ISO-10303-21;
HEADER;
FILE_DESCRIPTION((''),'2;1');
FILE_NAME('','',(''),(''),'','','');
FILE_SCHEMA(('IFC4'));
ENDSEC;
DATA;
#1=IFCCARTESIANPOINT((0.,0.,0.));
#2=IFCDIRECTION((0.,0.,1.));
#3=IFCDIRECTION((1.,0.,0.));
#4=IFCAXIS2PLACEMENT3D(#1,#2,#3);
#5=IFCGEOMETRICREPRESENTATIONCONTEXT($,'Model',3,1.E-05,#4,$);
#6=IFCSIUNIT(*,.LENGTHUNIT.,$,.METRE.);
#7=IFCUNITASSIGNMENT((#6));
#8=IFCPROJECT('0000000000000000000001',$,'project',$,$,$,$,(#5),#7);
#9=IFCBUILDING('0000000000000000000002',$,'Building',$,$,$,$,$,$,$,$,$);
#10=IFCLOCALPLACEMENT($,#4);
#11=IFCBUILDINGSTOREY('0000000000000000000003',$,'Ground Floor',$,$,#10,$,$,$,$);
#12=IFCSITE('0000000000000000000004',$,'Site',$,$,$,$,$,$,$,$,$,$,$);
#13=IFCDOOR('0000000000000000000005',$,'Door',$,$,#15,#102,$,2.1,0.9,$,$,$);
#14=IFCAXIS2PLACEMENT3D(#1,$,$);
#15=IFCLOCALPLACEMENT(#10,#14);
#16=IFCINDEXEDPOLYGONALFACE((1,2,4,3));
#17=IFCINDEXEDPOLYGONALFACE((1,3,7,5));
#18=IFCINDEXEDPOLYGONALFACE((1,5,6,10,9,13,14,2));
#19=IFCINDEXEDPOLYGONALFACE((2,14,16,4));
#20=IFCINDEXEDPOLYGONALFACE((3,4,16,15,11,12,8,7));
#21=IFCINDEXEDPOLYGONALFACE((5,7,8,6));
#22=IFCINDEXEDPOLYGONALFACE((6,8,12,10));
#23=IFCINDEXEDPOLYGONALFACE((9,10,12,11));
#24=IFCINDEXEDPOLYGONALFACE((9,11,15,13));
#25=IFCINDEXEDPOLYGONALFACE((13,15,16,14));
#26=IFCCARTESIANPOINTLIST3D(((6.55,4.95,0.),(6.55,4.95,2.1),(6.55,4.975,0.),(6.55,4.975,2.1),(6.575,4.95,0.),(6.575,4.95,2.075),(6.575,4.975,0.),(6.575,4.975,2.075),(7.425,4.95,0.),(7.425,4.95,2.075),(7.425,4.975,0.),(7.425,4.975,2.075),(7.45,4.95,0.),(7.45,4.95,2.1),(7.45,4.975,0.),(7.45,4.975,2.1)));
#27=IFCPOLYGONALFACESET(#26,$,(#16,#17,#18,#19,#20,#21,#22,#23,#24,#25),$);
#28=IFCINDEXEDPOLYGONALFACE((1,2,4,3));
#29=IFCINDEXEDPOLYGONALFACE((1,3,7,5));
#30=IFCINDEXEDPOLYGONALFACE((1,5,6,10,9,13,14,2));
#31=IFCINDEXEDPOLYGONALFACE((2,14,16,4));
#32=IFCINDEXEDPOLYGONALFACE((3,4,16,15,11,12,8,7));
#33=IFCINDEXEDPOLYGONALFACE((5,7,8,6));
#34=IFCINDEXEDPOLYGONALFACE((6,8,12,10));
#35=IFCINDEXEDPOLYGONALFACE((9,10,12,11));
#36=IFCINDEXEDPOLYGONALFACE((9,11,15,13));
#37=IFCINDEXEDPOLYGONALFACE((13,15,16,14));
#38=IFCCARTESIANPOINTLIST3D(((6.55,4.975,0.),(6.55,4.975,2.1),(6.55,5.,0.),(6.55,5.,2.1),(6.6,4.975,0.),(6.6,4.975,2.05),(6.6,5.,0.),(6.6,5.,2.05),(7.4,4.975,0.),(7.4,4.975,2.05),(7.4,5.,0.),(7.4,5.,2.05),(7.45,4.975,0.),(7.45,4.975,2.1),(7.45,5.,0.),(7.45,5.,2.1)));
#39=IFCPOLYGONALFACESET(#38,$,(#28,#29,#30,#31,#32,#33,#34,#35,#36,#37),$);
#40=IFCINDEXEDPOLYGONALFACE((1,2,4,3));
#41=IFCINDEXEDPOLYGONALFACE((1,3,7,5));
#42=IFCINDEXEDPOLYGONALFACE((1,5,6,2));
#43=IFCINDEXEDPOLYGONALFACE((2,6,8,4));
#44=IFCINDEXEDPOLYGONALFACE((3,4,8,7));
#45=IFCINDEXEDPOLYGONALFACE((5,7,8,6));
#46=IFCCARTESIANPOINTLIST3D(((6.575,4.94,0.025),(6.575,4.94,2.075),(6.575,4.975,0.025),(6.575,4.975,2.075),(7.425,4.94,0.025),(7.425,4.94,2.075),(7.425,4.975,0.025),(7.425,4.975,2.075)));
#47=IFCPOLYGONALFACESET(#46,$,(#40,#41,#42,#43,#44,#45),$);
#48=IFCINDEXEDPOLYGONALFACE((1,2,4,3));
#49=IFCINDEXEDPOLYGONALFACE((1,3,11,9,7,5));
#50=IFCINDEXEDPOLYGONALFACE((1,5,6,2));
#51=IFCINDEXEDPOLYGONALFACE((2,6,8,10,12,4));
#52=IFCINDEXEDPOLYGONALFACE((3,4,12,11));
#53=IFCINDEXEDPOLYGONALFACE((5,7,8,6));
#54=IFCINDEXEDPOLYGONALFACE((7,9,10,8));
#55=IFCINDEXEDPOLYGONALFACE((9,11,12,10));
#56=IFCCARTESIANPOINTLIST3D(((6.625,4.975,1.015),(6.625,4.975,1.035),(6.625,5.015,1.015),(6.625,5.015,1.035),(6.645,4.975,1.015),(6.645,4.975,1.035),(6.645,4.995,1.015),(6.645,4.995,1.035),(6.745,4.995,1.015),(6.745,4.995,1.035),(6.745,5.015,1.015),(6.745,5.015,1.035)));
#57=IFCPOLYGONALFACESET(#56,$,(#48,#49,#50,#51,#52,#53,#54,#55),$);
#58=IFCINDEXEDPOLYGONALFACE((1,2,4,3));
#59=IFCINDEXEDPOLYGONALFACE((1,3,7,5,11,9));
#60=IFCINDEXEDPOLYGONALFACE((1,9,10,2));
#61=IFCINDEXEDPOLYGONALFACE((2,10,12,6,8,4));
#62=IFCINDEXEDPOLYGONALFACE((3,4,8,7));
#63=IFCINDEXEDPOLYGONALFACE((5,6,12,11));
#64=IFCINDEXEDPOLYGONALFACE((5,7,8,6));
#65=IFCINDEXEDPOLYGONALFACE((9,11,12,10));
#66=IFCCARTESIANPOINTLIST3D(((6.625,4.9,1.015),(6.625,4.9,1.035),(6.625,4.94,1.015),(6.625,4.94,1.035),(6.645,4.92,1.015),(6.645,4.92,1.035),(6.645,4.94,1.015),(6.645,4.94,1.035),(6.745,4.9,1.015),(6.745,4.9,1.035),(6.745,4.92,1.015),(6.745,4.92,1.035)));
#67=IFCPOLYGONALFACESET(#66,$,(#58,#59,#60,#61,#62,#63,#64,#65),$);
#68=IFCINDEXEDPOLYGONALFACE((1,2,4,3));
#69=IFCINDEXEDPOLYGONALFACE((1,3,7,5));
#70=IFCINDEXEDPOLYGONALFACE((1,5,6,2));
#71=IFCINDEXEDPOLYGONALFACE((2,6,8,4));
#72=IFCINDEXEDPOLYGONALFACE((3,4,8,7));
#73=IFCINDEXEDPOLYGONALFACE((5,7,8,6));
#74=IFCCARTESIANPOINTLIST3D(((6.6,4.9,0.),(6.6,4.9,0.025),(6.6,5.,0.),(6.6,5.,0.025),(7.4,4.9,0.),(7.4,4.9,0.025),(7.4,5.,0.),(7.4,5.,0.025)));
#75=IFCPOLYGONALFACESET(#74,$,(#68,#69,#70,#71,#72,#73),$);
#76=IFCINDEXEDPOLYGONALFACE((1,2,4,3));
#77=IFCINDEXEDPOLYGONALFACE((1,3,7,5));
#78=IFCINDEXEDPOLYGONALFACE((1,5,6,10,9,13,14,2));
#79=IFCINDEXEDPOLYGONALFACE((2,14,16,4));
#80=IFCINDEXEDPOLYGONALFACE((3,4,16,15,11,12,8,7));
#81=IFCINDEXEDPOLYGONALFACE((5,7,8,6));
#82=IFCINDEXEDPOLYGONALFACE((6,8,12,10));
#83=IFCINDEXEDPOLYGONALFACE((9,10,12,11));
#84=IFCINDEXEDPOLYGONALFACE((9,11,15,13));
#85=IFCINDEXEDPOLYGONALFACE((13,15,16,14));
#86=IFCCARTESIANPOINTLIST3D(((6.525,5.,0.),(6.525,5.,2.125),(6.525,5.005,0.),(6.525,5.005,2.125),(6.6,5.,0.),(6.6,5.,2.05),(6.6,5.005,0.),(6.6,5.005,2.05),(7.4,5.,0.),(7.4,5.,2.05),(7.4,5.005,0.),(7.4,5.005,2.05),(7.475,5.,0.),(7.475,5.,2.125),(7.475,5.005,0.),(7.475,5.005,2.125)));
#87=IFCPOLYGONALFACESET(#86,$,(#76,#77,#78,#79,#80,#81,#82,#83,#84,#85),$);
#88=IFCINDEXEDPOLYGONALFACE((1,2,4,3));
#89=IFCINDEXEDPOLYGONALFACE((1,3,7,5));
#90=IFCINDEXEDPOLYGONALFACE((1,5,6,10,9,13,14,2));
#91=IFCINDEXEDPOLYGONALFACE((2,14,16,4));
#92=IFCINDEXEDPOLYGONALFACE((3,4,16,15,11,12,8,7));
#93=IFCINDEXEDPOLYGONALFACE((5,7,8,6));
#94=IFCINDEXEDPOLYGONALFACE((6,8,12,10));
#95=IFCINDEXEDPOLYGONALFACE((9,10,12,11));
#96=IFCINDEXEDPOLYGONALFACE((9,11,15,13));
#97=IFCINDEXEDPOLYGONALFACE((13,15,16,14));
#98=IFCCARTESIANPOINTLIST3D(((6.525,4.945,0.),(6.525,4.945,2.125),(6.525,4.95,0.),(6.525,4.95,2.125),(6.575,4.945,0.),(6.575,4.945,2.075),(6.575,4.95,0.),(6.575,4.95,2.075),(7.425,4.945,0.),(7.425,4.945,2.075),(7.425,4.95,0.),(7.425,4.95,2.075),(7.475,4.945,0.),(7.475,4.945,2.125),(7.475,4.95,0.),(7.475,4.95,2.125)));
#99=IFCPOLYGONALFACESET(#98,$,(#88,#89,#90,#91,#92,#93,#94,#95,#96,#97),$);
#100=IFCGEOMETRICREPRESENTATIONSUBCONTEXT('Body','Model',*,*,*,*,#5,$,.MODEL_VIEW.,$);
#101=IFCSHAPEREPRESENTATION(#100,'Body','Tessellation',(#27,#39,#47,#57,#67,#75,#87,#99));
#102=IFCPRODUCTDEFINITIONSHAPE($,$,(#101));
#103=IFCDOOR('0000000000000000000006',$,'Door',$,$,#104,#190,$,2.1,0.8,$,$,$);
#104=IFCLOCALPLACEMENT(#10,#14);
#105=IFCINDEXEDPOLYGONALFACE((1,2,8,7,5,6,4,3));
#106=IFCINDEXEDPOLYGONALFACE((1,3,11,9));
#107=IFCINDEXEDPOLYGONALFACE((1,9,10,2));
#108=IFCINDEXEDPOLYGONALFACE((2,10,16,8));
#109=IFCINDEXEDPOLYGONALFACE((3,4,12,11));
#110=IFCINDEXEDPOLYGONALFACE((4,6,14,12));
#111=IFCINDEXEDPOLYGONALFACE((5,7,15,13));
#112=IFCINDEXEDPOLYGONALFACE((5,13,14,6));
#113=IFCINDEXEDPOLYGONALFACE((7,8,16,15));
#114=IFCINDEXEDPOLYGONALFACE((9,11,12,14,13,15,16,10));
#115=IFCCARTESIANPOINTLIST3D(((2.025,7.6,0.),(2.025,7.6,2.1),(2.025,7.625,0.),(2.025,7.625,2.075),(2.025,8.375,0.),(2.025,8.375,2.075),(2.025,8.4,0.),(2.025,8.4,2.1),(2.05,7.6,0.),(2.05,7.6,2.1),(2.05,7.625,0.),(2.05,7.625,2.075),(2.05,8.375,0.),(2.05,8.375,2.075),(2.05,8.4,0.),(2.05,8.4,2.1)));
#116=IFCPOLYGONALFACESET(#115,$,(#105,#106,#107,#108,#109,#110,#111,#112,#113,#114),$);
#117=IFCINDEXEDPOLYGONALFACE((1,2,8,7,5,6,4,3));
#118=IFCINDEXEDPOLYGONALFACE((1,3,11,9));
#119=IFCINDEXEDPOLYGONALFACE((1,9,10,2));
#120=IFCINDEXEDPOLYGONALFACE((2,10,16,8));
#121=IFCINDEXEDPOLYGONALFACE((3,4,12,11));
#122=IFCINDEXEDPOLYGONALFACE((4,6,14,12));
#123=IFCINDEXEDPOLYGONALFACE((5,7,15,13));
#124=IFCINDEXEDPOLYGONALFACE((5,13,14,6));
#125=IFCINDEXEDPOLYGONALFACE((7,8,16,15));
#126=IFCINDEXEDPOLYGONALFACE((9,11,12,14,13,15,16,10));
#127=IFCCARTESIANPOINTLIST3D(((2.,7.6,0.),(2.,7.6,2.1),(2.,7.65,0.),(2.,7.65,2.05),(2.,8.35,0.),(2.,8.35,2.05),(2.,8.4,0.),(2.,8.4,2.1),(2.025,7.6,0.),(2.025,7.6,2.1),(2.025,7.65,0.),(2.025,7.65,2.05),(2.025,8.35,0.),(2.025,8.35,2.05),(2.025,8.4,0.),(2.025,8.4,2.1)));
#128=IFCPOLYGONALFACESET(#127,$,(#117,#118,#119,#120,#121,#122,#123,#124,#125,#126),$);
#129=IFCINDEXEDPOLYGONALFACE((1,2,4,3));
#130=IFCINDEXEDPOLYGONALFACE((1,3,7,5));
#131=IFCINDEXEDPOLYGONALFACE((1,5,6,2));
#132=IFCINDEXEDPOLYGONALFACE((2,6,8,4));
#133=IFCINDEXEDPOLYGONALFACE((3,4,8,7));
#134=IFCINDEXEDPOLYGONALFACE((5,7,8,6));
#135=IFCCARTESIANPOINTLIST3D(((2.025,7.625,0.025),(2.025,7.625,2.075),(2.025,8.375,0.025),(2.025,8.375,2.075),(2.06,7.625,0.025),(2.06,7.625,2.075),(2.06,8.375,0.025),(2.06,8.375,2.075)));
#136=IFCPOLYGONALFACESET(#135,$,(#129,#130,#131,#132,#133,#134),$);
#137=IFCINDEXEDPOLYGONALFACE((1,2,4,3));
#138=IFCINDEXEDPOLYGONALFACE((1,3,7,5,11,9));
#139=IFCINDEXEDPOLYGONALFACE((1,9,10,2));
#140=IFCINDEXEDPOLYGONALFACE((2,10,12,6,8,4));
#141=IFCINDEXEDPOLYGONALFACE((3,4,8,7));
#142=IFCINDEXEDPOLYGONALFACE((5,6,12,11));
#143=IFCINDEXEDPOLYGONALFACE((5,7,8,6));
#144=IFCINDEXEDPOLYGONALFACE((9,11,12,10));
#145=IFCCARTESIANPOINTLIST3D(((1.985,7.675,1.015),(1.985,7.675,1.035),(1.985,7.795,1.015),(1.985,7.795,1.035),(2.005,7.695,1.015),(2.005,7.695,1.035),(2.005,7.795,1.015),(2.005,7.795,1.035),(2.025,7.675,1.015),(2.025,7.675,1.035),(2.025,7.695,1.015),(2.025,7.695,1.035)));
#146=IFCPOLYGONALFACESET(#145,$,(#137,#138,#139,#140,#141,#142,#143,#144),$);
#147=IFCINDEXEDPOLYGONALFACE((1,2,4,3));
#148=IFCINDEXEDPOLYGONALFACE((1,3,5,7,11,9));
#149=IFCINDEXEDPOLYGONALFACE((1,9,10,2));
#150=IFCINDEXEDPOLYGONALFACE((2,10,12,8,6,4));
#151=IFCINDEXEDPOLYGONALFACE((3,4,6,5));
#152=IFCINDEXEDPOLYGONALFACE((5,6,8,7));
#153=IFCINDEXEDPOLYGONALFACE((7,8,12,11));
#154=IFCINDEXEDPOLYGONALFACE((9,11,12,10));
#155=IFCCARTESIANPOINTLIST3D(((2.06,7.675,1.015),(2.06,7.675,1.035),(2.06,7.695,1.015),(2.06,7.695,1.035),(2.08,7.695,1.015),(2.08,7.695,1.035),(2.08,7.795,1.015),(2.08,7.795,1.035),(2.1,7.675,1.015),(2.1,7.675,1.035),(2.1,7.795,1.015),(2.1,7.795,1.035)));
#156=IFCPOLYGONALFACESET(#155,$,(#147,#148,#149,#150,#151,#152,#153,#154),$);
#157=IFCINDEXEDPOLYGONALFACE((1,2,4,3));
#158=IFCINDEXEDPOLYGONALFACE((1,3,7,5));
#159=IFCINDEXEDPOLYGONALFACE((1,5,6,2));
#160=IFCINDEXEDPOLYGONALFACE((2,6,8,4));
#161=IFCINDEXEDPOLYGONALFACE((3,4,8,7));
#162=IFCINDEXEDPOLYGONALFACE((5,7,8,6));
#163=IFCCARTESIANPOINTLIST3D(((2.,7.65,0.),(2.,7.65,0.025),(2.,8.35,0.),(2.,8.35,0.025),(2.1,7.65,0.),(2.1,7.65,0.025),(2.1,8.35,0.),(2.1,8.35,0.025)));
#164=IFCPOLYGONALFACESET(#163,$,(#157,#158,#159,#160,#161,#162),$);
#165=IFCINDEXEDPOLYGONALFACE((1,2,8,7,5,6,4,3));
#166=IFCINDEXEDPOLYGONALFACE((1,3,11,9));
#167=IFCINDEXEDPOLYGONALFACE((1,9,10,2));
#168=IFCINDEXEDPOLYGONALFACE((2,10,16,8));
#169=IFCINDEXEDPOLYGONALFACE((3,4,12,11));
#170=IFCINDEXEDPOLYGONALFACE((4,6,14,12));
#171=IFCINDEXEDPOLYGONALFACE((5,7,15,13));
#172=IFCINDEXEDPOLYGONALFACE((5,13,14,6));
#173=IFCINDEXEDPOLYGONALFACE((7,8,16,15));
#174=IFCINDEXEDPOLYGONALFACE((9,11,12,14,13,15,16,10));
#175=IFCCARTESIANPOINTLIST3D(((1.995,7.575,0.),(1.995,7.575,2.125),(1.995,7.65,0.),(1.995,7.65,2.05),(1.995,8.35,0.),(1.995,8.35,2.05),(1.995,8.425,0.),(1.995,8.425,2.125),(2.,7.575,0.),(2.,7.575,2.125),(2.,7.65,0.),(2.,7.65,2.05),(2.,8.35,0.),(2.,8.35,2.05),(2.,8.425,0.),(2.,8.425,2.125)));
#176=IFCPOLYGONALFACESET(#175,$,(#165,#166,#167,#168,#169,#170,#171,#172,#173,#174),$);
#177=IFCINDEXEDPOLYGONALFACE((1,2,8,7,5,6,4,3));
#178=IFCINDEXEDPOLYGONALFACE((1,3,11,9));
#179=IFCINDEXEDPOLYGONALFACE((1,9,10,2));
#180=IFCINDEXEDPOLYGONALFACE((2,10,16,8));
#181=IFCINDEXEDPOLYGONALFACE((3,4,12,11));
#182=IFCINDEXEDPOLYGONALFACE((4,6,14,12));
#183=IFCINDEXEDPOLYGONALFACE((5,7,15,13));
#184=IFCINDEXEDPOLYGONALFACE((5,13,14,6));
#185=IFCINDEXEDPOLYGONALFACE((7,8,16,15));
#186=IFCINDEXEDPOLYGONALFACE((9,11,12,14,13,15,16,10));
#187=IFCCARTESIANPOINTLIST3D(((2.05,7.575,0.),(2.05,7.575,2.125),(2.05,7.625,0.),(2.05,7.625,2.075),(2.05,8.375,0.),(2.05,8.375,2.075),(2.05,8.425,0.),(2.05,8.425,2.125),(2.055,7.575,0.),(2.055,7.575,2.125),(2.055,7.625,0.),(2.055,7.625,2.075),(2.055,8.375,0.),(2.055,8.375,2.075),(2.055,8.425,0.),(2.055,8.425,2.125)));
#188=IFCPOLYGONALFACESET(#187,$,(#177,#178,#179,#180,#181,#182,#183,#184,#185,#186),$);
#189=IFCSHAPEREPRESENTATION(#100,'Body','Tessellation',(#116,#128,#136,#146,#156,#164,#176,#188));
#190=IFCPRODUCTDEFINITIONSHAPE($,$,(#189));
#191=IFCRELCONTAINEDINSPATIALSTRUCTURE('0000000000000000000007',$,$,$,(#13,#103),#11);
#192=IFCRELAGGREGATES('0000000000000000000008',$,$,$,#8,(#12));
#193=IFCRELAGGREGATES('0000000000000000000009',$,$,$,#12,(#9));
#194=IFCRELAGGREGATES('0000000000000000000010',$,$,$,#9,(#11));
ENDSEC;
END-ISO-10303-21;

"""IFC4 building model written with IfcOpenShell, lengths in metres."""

from ifc_helpers import new_model, si_unit, frame, origin_with_axes, place, context, subcontext, project, spatial, line, indexed_curve, outline, extrude, element, save


model = new_model("IFC4")

# Units and contexts
model_context = context("Model", 3, precision=1e-05, world=origin_with_axes())
body_context = subcontext(model_context, "Body", "Model", "MODEL_VIEW")
ifc_project = project(units=[si_unit("LENGTHUNIT", "METRE")], contexts=[model_context])

# Site, building, storey
site = spatial("IfcSite", under=ifc_project, Name="Site")
building = spatial("IfcBuilding", under=site, Name="Building")
storey_placement = place(None, origin_with_axes())
storey = spatial("IfcBuildingStorey", under=building, at=storey_placement, Name="Ground Floor")

# Doors
door_1_placement = place(storey_placement, frame((7.45, 5.0, 0.0), z_axis=(0.0, 0.0, 1.0), x_axis=(-1.0, 0.0, 0.0)))
element("IfcDoor", 1, at=door_1_placement, inside=storey, Name="Door", OverallHeight=2.1, OverallWidth=0.9, context=body_context, shape_type="SweptSolid", body=[
    extrude(outline(indexed_curve([(0.0, 0.0), (0.0, 2.1), (0.9, 2.1), (0.9, 0.0), (0.875, 0.0), (0.875, 2.075), (0.025, 2.075), (0.025, 0.0)], segments=[line(1, 2, 3, 4, 5, 6, 7, 8, 1)])), frame((0.0, 0.025, 0.0), z_axis=(0.0, -1.0, 0.0), x_axis=(1.0, 0.0, 0.0)), (0.0, 0.0, -1.0), 0.025),
    extrude(outline(indexed_curve([(0.0, 0.0), (0.0, 2.1), (0.9, 2.1), (0.9, 0.0), (0.85, 0.0), (0.85, 2.05), (0.05, 2.05), (0.05, 0.0)], segments=[line(1, 2, 3, 4, 5, 6, 7, 8, 1)])), frame((0.0, 0.0, 0.0), z_axis=(0.0, -1.0, 0.0), x_axis=(1.0, 0.0, 0.0)), (0.0, 0.0, -1.0), 0.025),
    extrude(outline(indexed_curve([(0.0, 0.0), (0.85, 0.0), (0.85, 0.035), (0.0, 0.035)], segments=[line(1, 2, 3, 4, 1)])), frame((0.025, 0.025, 0.025), z_axis=(0.0, 0.0, 1.0), x_axis=(1.0, 0.0, 0.0)), (0.0, 0.0, 1.0), 2.05),
    extrude(outline(indexed_curve([(0.0, 0.0), (0.0, -0.04), (-0.12, -0.04), (-0.12, -0.02), (-0.02, -0.02), (-0.02, 0.0)], segments=[line(1, 2, 3, 4, 5, 6, 1)])), frame((0.825, 0.025, 1.015), z_axis=(0.0, 0.0, 1.0), x_axis=(1.0, 0.0, 0.0)), (0.0, 0.0, 1.0), 0.02),
    extrude(outline(indexed_curve([(0.0, 0.0), (0.0, 0.04), (-0.12, 0.04), (-0.12, 0.02), (-0.02, 0.02), (-0.02, 0.0)], segments=[line(1, 2, 3, 4, 5, 6, 1)])), frame((0.825, 0.06, 1.015), z_axis=(0.0, 0.0, 1.0), x_axis=(1.0, 0.0, 0.0)), (0.0, 0.0, 1.0), 0.02),
    extrude(outline(indexed_curve([(0.0, 0.0), (0.8, 0.0), (0.8, 0.1), (0.0, 0.1)], segments=[line(1, 2, 3, 4, 1)])), frame((0.05, 0.0, 0.0), z_axis=(0.0, 0.0, 1.0), x_axis=(1.0, 0.0, 0.0)), (0.0, 0.0, 1.0), 0.025),
    extrude(outline(indexed_curve([(0.0, 0.0), (0.0, 2.125), (0.95, 2.125), (0.95, 0.0), (0.875, 0.0), (0.875, 2.05), (0.075, 2.05), (0.075, 0.0)], segments=[line(1, 2, 3, 4, 5, 6, 7, 8, 1)])), frame((-0.025, -0.005, 0.0), z_axis=(0.0, -1.0, 0.0), x_axis=(1.0, 0.0, 0.0)), (0.0, 0.0, -1.0), 0.005),
    extrude(outline(indexed_curve([(0.0, 0.0), (0.0, 2.125), (0.95, 2.125), (0.95, 0.0), (0.9, 0.0), (0.9, 2.075), (0.05, 2.075), (0.05, 0.0)], segments=[line(1, 2, 3, 4, 5, 6, 7, 8, 1)])), frame((-0.025, 0.05, 0.0), z_axis=(0.0, -1.0, 0.0), x_axis=(1.0, 0.0, 0.0)), (0.0, 0.0, -1.0), 0.005),
])
door_2_placement = place(storey_placement, frame((2.0, 8.4, 0.0), z_axis=(0.0, 0.0, 1.0), x_axis=(0.0, -1.0, 0.0)))
element("IfcDoor", 2, at=door_2_placement, inside=storey, Name="Door", OverallHeight=2.1, OverallWidth=0.8, context=body_context, shape_type="SweptSolid", body=[
    extrude(outline(indexed_curve([(0.0, 0.0), (0.0, 2.1), (0.8, 2.1), (0.8, 0.0), (0.775, 0.0), (0.775, 2.075), (0.025, 2.075), (0.025, 0.0)], segments=[line(1, 2, 3, 4, 5, 6, 7, 8, 1)])), frame((0.0, 0.025, 0.0), z_axis=(0.0, -1.0, 0.0), x_axis=(1.0, 0.0, 0.0)), (0.0, 0.0, -1.0), 0.025),
    extrude(outline(indexed_curve([(0.0, 0.0), (0.0, 2.1), (0.8, 2.1), (0.8, 0.0), (0.75, 0.0), (0.75, 2.05), (0.05, 2.05), (0.05, 0.0)], segments=[line(1, 2, 3, 4, 5, 6, 7, 8, 1)])), frame((0.0, 0.0, 0.0), z_axis=(0.0, -1.0, 0.0), x_axis=(1.0, 0.0, 0.0)), (0.0, 0.0, -1.0), 0.025),
    extrude(outline(indexed_curve([(0.0, 0.0), (0.75, 0.0), (0.75, 0.035), (0.0, 0.035)], segments=[line(1, 2, 3, 4, 1)])), frame((0.025, 0.025, 0.025), z_axis=(0.0, 0.0, 1.0), x_axis=(1.0, 0.0, 0.0)), (0.0, 0.0, 1.0), 2.05),
    extrude(outline(indexed_curve([(0.0, 0.0), (0.0, -0.04), (-0.12, -0.04), (-0.12, -0.02), (-0.02, -0.02), (-0.02, 0.0)], segments=[line(1, 2, 3, 4, 5, 6, 1)])), frame((0.725, 0.025, 1.015), z_axis=(0.0, 0.0, 1.0), x_axis=(1.0, 0.0, 0.0)), (0.0, 0.0, 1.0), 0.02),
    extrude(outline(indexed_curve([(0.0, 0.0), (0.0, 0.04), (-0.12, 0.04), (-0.12, 0.02), (-0.02, 0.02), (-0.02, 0.0)], segments=[line(1, 2, 3, 4, 5, 6, 1)])), frame((0.725, 0.06, 1.015), z_axis=(0.0, 0.0, 1.0), x_axis=(1.0, 0.0, 0.0)), (0.0, 0.0, 1.0), 0.02),
    extrude(outline(indexed_curve([(0.0, 0.0), (0.7, 0.0), (0.7, 0.1), (0.0, 0.1)], segments=[line(1, 2, 3, 4, 1)])), frame((0.05, 0.0, 0.0), z_axis=(0.0, 0.0, 1.0), x_axis=(1.0, 0.0, 0.0)), (0.0, 0.0, 1.0), 0.025),
    extrude(outline(indexed_curve([(0.0, 0.0), (0.0, 2.125), (0.85, 2.125), (0.85, 0.0), (0.775, 0.0), (0.775, 2.05), (0.075, 2.05), (0.075, 0.0)], segments=[line(1, 2, 3, 4, 5, 6, 7, 8, 1)])), frame((-0.025, -0.005, 0.0), z_axis=(0.0, -1.0, 0.0), x_axis=(1.0, 0.0, 0.0)), (0.0, 0.0, -1.0), 0.005),
    extrude(outline(indexed_curve([(0.0, 0.0), (0.0, 2.125), (0.85, 2.125), (0.85, 0.0), (0.8, 0.0), (0.8, 2.075), (0.05, 2.075), (0.05, 0.0)], segments=[line(1, 2, 3, 4, 5, 6, 7, 8, 1)])), frame((-0.025, 0.05, 0.0), z_axis=(0.0, -1.0, 0.0), x_axis=(1.0, 0.0, 0.0)), (0.0, 0.0, -1.0), 0.005),
])

save(model, "model.ifc")
